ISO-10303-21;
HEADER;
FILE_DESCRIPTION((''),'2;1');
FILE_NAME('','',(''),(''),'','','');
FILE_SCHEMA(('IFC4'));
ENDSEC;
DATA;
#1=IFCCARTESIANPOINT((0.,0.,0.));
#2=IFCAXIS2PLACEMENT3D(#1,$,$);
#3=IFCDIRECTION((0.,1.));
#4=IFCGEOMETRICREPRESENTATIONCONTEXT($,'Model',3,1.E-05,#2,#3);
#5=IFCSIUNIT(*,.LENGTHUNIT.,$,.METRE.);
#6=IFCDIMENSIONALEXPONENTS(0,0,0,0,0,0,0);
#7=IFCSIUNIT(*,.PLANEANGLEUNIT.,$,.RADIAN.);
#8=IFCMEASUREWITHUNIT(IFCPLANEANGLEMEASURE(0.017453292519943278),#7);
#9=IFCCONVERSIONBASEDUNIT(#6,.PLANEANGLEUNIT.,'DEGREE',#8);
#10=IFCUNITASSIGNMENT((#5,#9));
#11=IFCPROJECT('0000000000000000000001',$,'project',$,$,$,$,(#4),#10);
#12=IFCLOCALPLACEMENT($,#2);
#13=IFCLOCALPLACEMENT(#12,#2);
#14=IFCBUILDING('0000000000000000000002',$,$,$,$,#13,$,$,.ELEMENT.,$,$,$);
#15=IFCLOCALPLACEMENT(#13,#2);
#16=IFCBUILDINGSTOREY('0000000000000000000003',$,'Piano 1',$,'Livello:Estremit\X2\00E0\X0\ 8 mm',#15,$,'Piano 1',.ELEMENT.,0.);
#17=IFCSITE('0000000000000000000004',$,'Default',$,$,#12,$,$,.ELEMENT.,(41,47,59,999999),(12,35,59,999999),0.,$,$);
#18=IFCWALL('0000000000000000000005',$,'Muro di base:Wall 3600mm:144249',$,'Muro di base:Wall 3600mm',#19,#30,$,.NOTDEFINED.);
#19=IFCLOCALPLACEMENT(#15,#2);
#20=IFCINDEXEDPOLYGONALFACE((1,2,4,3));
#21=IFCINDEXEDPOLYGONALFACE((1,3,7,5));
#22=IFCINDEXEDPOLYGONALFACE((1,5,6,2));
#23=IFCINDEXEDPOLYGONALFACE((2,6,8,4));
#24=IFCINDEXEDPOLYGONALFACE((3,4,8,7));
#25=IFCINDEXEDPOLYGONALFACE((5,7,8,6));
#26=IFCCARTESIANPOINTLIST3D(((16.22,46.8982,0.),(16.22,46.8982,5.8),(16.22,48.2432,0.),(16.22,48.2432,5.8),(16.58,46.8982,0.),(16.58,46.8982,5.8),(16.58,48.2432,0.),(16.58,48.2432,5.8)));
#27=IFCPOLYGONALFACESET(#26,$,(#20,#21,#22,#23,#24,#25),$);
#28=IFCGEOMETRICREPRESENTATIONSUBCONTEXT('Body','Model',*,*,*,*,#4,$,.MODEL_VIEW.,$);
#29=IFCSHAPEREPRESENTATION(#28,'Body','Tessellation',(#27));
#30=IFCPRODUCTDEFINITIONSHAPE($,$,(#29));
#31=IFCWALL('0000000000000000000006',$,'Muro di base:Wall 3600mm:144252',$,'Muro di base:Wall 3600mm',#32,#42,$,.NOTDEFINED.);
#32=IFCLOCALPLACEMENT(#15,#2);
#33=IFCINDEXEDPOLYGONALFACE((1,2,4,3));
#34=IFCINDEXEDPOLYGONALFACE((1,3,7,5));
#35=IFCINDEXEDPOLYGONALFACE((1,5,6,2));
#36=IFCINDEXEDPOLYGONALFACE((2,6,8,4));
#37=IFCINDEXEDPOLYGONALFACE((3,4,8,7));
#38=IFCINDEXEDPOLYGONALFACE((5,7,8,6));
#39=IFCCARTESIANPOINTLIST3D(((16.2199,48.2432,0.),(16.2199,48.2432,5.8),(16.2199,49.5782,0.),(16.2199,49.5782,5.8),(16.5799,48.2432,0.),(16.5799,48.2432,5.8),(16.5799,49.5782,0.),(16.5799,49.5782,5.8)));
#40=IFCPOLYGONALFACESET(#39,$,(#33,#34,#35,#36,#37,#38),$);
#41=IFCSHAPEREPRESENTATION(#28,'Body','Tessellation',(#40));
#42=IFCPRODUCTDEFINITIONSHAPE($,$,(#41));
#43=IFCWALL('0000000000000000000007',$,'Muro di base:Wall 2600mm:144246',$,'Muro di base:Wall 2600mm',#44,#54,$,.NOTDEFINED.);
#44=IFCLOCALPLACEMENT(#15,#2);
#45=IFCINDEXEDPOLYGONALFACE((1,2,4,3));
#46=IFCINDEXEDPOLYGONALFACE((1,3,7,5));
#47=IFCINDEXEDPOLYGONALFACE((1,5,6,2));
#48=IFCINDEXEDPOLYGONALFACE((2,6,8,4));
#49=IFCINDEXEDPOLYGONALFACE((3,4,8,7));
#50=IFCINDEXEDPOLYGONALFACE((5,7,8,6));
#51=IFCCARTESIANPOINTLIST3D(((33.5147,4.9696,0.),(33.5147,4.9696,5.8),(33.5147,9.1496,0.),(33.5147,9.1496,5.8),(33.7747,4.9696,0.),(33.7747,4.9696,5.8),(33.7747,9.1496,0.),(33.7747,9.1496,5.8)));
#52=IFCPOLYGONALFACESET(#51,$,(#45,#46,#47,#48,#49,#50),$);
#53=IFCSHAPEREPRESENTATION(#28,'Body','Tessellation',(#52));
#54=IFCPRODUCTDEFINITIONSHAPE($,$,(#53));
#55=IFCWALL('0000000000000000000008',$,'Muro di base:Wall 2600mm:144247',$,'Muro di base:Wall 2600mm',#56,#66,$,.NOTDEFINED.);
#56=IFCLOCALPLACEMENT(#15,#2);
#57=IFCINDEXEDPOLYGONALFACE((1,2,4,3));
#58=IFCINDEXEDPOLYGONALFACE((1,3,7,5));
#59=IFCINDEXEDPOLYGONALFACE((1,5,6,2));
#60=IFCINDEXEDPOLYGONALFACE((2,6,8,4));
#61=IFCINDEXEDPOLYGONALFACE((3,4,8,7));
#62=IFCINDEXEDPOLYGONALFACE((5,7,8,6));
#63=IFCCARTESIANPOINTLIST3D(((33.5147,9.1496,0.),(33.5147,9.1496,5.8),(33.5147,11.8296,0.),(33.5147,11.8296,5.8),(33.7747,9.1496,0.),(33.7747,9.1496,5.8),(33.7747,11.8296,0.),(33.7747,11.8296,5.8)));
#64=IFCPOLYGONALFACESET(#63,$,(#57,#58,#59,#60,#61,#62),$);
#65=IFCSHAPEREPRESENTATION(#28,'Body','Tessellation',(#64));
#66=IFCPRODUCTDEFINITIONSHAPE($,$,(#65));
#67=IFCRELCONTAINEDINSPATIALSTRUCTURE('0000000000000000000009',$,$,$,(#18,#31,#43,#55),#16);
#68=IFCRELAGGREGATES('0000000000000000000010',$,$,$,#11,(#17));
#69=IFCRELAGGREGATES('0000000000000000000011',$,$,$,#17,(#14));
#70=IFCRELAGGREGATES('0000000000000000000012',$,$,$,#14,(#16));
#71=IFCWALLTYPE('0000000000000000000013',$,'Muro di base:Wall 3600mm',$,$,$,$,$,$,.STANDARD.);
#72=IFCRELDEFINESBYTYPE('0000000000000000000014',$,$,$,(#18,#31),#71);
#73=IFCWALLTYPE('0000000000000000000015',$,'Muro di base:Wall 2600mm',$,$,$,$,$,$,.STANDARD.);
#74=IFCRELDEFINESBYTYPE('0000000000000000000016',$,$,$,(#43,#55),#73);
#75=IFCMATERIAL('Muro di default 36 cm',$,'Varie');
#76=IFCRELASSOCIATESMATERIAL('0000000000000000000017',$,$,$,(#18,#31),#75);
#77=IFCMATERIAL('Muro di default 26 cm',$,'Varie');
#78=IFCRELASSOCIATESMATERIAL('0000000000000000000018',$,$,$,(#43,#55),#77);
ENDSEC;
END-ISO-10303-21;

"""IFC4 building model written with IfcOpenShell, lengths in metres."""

from ifc_helpers import new_model, entity, si_unit, converted_unit, direction, frame, origin, place, context, subcontext, project, spatial, indexed_curve, outline, extrude, material, type_object, element, save


model = new_model("IFC4")

# Units and contexts
model_context = context("Model", 3, precision=1e-05, world=origin(), true_north=direction((0.0, 1.0)))
body_context = subcontext(model_context, "Body", "Model", "MODEL_VIEW")
ifc_project = project(units=[si_unit("LENGTHUNIT", "METRE"), converted_unit("PLANEANGLEUNIT", "DEGREE", entity("IfcPlaneAngleMeasure", 0.017453292519943278), si_unit("PLANEANGLEUNIT", "RADIAN"), dimensions=[0, 0, 0, 0, 0, 0, 0])], contexts=[model_context])

# Site, building, storey
site_placement = place(None, origin())
site = spatial("IfcSite", under=ifc_project, at=site_placement, Name="Default", CompositionType="ELEMENT", RefLatitude=(41, 47, 59, 999999), RefLongitude=(12, 35, 59, 999999), RefElevation=0.0)
building_placement = place(site_placement, origin())
building = spatial("IfcBuilding", under=site, at=building_placement, CompositionType="ELEMENT")
storey_placement = place(building_placement, origin())
storey = spatial("IfcBuildingStorey", under=building, at=storey_placement, Name="Piano 1", ObjectType="Livello:Estremità 8 mm", LongName="Piano 1", CompositionType="ELEMENT", Elevation=0.0)

# Walls
ifc_material_1 = material(Name="Muro di default 36 cm", Category="Varie")
wall_type_1 = type_object("IfcWallType", Name="Muro di base:Wall 3600mm", PredefinedType="STANDARD")
wall_1_placement = place(storey_placement, frame((16.4, 46.8982, 0.0), z_axis=(0.0, 0.0, 1.0), x_axis=(0.0, 1.0, 0.0)))
element("IfcWall", 1, at=wall_1_placement, inside=storey, type_object=wall_type_1, material=ifc_material_1, Name="Muro di base:Wall 3600mm:144249", ObjectType="Muro di base:Wall 3600mm", PredefinedType="NOTDEFINED", context=body_context, shape_type="SweptSolid", body=[
    extrude(outline(indexed_curve([(1.345, 0.18), (0.0, 0.18), (0.0, -0.18), (1.345, -0.18), (1.345, 0.18)], self_intersect=False)), origin(), (0.0, 0.0, 1.0), 5.8),
])
wall_2_placement = place(storey_placement, frame((16.3999, 48.2432, 0.0), z_axis=(0.0, 0.0, 1.0), x_axis=(0.0, 1.0, 0.0)))
element("IfcWall", 2, at=wall_2_placement, inside=storey, type_object=wall_type_1, material=ifc_material_1, Name="Muro di base:Wall 3600mm:144252", ObjectType="Muro di base:Wall 3600mm", PredefinedType="NOTDEFINED", context=body_context, shape_type="SweptSolid", body=[
    extrude(outline(indexed_curve([(1.335, 0.18), (0.0, 0.18), (0.0, -0.18), (1.335, -0.18), (1.335, 0.18)], self_intersect=False)), origin(), (0.0, 0.0, 1.0), 5.8),
])
ifc_material_2 = material(Name="Muro di default 26 cm", Category="Varie")
wall_type_2 = type_object("IfcWallType", Name="Muro di base:Wall 2600mm", PredefinedType="STANDARD")
wall_3_placement = place(storey_placement, frame((33.6447, 4.9696, 0.0), z_axis=(0.0, 0.0, 1.0), x_axis=(0.0, 1.0, 0.0)))
element("IfcWall", 3, at=wall_3_placement, inside=storey, type_object=wall_type_2, material=ifc_material_2, Name="Muro di base:Wall 2600mm:144246", ObjectType="Muro di base:Wall 2600mm", PredefinedType="NOTDEFINED", context=body_context, shape_type="SweptSolid", body=[
    extrude(outline(indexed_curve([(4.18, 0.13), (0.0, 0.13), (0.0, -0.13), (4.18, -0.13), (4.18, 0.13)], self_intersect=False)), origin(), (0.0, 0.0, 1.0), 5.8),
])
wall_4_placement = place(storey_placement, frame((33.6447, 9.1496, 0.0), z_axis=(0.0, 0.0, 1.0), x_axis=(0.0, 1.0, 0.0)))
element("IfcWall", 4, at=wall_4_placement, inside=storey, type_object=wall_type_2, material=ifc_material_2, Name="Muro di base:Wall 2600mm:144247", ObjectType="Muro di base:Wall 2600mm", PredefinedType="NOTDEFINED", context=body_context, shape_type="SweptSolid", body=[
    extrude(outline(indexed_curve([(2.68, 0.13), (0.0, 0.13), (0.0, -0.13), (2.68, -0.13), (2.68, 0.13)], self_intersect=False)), origin(), (0.0, 0.0, 1.0), 5.8),
])

save(model, "model.ifc")
